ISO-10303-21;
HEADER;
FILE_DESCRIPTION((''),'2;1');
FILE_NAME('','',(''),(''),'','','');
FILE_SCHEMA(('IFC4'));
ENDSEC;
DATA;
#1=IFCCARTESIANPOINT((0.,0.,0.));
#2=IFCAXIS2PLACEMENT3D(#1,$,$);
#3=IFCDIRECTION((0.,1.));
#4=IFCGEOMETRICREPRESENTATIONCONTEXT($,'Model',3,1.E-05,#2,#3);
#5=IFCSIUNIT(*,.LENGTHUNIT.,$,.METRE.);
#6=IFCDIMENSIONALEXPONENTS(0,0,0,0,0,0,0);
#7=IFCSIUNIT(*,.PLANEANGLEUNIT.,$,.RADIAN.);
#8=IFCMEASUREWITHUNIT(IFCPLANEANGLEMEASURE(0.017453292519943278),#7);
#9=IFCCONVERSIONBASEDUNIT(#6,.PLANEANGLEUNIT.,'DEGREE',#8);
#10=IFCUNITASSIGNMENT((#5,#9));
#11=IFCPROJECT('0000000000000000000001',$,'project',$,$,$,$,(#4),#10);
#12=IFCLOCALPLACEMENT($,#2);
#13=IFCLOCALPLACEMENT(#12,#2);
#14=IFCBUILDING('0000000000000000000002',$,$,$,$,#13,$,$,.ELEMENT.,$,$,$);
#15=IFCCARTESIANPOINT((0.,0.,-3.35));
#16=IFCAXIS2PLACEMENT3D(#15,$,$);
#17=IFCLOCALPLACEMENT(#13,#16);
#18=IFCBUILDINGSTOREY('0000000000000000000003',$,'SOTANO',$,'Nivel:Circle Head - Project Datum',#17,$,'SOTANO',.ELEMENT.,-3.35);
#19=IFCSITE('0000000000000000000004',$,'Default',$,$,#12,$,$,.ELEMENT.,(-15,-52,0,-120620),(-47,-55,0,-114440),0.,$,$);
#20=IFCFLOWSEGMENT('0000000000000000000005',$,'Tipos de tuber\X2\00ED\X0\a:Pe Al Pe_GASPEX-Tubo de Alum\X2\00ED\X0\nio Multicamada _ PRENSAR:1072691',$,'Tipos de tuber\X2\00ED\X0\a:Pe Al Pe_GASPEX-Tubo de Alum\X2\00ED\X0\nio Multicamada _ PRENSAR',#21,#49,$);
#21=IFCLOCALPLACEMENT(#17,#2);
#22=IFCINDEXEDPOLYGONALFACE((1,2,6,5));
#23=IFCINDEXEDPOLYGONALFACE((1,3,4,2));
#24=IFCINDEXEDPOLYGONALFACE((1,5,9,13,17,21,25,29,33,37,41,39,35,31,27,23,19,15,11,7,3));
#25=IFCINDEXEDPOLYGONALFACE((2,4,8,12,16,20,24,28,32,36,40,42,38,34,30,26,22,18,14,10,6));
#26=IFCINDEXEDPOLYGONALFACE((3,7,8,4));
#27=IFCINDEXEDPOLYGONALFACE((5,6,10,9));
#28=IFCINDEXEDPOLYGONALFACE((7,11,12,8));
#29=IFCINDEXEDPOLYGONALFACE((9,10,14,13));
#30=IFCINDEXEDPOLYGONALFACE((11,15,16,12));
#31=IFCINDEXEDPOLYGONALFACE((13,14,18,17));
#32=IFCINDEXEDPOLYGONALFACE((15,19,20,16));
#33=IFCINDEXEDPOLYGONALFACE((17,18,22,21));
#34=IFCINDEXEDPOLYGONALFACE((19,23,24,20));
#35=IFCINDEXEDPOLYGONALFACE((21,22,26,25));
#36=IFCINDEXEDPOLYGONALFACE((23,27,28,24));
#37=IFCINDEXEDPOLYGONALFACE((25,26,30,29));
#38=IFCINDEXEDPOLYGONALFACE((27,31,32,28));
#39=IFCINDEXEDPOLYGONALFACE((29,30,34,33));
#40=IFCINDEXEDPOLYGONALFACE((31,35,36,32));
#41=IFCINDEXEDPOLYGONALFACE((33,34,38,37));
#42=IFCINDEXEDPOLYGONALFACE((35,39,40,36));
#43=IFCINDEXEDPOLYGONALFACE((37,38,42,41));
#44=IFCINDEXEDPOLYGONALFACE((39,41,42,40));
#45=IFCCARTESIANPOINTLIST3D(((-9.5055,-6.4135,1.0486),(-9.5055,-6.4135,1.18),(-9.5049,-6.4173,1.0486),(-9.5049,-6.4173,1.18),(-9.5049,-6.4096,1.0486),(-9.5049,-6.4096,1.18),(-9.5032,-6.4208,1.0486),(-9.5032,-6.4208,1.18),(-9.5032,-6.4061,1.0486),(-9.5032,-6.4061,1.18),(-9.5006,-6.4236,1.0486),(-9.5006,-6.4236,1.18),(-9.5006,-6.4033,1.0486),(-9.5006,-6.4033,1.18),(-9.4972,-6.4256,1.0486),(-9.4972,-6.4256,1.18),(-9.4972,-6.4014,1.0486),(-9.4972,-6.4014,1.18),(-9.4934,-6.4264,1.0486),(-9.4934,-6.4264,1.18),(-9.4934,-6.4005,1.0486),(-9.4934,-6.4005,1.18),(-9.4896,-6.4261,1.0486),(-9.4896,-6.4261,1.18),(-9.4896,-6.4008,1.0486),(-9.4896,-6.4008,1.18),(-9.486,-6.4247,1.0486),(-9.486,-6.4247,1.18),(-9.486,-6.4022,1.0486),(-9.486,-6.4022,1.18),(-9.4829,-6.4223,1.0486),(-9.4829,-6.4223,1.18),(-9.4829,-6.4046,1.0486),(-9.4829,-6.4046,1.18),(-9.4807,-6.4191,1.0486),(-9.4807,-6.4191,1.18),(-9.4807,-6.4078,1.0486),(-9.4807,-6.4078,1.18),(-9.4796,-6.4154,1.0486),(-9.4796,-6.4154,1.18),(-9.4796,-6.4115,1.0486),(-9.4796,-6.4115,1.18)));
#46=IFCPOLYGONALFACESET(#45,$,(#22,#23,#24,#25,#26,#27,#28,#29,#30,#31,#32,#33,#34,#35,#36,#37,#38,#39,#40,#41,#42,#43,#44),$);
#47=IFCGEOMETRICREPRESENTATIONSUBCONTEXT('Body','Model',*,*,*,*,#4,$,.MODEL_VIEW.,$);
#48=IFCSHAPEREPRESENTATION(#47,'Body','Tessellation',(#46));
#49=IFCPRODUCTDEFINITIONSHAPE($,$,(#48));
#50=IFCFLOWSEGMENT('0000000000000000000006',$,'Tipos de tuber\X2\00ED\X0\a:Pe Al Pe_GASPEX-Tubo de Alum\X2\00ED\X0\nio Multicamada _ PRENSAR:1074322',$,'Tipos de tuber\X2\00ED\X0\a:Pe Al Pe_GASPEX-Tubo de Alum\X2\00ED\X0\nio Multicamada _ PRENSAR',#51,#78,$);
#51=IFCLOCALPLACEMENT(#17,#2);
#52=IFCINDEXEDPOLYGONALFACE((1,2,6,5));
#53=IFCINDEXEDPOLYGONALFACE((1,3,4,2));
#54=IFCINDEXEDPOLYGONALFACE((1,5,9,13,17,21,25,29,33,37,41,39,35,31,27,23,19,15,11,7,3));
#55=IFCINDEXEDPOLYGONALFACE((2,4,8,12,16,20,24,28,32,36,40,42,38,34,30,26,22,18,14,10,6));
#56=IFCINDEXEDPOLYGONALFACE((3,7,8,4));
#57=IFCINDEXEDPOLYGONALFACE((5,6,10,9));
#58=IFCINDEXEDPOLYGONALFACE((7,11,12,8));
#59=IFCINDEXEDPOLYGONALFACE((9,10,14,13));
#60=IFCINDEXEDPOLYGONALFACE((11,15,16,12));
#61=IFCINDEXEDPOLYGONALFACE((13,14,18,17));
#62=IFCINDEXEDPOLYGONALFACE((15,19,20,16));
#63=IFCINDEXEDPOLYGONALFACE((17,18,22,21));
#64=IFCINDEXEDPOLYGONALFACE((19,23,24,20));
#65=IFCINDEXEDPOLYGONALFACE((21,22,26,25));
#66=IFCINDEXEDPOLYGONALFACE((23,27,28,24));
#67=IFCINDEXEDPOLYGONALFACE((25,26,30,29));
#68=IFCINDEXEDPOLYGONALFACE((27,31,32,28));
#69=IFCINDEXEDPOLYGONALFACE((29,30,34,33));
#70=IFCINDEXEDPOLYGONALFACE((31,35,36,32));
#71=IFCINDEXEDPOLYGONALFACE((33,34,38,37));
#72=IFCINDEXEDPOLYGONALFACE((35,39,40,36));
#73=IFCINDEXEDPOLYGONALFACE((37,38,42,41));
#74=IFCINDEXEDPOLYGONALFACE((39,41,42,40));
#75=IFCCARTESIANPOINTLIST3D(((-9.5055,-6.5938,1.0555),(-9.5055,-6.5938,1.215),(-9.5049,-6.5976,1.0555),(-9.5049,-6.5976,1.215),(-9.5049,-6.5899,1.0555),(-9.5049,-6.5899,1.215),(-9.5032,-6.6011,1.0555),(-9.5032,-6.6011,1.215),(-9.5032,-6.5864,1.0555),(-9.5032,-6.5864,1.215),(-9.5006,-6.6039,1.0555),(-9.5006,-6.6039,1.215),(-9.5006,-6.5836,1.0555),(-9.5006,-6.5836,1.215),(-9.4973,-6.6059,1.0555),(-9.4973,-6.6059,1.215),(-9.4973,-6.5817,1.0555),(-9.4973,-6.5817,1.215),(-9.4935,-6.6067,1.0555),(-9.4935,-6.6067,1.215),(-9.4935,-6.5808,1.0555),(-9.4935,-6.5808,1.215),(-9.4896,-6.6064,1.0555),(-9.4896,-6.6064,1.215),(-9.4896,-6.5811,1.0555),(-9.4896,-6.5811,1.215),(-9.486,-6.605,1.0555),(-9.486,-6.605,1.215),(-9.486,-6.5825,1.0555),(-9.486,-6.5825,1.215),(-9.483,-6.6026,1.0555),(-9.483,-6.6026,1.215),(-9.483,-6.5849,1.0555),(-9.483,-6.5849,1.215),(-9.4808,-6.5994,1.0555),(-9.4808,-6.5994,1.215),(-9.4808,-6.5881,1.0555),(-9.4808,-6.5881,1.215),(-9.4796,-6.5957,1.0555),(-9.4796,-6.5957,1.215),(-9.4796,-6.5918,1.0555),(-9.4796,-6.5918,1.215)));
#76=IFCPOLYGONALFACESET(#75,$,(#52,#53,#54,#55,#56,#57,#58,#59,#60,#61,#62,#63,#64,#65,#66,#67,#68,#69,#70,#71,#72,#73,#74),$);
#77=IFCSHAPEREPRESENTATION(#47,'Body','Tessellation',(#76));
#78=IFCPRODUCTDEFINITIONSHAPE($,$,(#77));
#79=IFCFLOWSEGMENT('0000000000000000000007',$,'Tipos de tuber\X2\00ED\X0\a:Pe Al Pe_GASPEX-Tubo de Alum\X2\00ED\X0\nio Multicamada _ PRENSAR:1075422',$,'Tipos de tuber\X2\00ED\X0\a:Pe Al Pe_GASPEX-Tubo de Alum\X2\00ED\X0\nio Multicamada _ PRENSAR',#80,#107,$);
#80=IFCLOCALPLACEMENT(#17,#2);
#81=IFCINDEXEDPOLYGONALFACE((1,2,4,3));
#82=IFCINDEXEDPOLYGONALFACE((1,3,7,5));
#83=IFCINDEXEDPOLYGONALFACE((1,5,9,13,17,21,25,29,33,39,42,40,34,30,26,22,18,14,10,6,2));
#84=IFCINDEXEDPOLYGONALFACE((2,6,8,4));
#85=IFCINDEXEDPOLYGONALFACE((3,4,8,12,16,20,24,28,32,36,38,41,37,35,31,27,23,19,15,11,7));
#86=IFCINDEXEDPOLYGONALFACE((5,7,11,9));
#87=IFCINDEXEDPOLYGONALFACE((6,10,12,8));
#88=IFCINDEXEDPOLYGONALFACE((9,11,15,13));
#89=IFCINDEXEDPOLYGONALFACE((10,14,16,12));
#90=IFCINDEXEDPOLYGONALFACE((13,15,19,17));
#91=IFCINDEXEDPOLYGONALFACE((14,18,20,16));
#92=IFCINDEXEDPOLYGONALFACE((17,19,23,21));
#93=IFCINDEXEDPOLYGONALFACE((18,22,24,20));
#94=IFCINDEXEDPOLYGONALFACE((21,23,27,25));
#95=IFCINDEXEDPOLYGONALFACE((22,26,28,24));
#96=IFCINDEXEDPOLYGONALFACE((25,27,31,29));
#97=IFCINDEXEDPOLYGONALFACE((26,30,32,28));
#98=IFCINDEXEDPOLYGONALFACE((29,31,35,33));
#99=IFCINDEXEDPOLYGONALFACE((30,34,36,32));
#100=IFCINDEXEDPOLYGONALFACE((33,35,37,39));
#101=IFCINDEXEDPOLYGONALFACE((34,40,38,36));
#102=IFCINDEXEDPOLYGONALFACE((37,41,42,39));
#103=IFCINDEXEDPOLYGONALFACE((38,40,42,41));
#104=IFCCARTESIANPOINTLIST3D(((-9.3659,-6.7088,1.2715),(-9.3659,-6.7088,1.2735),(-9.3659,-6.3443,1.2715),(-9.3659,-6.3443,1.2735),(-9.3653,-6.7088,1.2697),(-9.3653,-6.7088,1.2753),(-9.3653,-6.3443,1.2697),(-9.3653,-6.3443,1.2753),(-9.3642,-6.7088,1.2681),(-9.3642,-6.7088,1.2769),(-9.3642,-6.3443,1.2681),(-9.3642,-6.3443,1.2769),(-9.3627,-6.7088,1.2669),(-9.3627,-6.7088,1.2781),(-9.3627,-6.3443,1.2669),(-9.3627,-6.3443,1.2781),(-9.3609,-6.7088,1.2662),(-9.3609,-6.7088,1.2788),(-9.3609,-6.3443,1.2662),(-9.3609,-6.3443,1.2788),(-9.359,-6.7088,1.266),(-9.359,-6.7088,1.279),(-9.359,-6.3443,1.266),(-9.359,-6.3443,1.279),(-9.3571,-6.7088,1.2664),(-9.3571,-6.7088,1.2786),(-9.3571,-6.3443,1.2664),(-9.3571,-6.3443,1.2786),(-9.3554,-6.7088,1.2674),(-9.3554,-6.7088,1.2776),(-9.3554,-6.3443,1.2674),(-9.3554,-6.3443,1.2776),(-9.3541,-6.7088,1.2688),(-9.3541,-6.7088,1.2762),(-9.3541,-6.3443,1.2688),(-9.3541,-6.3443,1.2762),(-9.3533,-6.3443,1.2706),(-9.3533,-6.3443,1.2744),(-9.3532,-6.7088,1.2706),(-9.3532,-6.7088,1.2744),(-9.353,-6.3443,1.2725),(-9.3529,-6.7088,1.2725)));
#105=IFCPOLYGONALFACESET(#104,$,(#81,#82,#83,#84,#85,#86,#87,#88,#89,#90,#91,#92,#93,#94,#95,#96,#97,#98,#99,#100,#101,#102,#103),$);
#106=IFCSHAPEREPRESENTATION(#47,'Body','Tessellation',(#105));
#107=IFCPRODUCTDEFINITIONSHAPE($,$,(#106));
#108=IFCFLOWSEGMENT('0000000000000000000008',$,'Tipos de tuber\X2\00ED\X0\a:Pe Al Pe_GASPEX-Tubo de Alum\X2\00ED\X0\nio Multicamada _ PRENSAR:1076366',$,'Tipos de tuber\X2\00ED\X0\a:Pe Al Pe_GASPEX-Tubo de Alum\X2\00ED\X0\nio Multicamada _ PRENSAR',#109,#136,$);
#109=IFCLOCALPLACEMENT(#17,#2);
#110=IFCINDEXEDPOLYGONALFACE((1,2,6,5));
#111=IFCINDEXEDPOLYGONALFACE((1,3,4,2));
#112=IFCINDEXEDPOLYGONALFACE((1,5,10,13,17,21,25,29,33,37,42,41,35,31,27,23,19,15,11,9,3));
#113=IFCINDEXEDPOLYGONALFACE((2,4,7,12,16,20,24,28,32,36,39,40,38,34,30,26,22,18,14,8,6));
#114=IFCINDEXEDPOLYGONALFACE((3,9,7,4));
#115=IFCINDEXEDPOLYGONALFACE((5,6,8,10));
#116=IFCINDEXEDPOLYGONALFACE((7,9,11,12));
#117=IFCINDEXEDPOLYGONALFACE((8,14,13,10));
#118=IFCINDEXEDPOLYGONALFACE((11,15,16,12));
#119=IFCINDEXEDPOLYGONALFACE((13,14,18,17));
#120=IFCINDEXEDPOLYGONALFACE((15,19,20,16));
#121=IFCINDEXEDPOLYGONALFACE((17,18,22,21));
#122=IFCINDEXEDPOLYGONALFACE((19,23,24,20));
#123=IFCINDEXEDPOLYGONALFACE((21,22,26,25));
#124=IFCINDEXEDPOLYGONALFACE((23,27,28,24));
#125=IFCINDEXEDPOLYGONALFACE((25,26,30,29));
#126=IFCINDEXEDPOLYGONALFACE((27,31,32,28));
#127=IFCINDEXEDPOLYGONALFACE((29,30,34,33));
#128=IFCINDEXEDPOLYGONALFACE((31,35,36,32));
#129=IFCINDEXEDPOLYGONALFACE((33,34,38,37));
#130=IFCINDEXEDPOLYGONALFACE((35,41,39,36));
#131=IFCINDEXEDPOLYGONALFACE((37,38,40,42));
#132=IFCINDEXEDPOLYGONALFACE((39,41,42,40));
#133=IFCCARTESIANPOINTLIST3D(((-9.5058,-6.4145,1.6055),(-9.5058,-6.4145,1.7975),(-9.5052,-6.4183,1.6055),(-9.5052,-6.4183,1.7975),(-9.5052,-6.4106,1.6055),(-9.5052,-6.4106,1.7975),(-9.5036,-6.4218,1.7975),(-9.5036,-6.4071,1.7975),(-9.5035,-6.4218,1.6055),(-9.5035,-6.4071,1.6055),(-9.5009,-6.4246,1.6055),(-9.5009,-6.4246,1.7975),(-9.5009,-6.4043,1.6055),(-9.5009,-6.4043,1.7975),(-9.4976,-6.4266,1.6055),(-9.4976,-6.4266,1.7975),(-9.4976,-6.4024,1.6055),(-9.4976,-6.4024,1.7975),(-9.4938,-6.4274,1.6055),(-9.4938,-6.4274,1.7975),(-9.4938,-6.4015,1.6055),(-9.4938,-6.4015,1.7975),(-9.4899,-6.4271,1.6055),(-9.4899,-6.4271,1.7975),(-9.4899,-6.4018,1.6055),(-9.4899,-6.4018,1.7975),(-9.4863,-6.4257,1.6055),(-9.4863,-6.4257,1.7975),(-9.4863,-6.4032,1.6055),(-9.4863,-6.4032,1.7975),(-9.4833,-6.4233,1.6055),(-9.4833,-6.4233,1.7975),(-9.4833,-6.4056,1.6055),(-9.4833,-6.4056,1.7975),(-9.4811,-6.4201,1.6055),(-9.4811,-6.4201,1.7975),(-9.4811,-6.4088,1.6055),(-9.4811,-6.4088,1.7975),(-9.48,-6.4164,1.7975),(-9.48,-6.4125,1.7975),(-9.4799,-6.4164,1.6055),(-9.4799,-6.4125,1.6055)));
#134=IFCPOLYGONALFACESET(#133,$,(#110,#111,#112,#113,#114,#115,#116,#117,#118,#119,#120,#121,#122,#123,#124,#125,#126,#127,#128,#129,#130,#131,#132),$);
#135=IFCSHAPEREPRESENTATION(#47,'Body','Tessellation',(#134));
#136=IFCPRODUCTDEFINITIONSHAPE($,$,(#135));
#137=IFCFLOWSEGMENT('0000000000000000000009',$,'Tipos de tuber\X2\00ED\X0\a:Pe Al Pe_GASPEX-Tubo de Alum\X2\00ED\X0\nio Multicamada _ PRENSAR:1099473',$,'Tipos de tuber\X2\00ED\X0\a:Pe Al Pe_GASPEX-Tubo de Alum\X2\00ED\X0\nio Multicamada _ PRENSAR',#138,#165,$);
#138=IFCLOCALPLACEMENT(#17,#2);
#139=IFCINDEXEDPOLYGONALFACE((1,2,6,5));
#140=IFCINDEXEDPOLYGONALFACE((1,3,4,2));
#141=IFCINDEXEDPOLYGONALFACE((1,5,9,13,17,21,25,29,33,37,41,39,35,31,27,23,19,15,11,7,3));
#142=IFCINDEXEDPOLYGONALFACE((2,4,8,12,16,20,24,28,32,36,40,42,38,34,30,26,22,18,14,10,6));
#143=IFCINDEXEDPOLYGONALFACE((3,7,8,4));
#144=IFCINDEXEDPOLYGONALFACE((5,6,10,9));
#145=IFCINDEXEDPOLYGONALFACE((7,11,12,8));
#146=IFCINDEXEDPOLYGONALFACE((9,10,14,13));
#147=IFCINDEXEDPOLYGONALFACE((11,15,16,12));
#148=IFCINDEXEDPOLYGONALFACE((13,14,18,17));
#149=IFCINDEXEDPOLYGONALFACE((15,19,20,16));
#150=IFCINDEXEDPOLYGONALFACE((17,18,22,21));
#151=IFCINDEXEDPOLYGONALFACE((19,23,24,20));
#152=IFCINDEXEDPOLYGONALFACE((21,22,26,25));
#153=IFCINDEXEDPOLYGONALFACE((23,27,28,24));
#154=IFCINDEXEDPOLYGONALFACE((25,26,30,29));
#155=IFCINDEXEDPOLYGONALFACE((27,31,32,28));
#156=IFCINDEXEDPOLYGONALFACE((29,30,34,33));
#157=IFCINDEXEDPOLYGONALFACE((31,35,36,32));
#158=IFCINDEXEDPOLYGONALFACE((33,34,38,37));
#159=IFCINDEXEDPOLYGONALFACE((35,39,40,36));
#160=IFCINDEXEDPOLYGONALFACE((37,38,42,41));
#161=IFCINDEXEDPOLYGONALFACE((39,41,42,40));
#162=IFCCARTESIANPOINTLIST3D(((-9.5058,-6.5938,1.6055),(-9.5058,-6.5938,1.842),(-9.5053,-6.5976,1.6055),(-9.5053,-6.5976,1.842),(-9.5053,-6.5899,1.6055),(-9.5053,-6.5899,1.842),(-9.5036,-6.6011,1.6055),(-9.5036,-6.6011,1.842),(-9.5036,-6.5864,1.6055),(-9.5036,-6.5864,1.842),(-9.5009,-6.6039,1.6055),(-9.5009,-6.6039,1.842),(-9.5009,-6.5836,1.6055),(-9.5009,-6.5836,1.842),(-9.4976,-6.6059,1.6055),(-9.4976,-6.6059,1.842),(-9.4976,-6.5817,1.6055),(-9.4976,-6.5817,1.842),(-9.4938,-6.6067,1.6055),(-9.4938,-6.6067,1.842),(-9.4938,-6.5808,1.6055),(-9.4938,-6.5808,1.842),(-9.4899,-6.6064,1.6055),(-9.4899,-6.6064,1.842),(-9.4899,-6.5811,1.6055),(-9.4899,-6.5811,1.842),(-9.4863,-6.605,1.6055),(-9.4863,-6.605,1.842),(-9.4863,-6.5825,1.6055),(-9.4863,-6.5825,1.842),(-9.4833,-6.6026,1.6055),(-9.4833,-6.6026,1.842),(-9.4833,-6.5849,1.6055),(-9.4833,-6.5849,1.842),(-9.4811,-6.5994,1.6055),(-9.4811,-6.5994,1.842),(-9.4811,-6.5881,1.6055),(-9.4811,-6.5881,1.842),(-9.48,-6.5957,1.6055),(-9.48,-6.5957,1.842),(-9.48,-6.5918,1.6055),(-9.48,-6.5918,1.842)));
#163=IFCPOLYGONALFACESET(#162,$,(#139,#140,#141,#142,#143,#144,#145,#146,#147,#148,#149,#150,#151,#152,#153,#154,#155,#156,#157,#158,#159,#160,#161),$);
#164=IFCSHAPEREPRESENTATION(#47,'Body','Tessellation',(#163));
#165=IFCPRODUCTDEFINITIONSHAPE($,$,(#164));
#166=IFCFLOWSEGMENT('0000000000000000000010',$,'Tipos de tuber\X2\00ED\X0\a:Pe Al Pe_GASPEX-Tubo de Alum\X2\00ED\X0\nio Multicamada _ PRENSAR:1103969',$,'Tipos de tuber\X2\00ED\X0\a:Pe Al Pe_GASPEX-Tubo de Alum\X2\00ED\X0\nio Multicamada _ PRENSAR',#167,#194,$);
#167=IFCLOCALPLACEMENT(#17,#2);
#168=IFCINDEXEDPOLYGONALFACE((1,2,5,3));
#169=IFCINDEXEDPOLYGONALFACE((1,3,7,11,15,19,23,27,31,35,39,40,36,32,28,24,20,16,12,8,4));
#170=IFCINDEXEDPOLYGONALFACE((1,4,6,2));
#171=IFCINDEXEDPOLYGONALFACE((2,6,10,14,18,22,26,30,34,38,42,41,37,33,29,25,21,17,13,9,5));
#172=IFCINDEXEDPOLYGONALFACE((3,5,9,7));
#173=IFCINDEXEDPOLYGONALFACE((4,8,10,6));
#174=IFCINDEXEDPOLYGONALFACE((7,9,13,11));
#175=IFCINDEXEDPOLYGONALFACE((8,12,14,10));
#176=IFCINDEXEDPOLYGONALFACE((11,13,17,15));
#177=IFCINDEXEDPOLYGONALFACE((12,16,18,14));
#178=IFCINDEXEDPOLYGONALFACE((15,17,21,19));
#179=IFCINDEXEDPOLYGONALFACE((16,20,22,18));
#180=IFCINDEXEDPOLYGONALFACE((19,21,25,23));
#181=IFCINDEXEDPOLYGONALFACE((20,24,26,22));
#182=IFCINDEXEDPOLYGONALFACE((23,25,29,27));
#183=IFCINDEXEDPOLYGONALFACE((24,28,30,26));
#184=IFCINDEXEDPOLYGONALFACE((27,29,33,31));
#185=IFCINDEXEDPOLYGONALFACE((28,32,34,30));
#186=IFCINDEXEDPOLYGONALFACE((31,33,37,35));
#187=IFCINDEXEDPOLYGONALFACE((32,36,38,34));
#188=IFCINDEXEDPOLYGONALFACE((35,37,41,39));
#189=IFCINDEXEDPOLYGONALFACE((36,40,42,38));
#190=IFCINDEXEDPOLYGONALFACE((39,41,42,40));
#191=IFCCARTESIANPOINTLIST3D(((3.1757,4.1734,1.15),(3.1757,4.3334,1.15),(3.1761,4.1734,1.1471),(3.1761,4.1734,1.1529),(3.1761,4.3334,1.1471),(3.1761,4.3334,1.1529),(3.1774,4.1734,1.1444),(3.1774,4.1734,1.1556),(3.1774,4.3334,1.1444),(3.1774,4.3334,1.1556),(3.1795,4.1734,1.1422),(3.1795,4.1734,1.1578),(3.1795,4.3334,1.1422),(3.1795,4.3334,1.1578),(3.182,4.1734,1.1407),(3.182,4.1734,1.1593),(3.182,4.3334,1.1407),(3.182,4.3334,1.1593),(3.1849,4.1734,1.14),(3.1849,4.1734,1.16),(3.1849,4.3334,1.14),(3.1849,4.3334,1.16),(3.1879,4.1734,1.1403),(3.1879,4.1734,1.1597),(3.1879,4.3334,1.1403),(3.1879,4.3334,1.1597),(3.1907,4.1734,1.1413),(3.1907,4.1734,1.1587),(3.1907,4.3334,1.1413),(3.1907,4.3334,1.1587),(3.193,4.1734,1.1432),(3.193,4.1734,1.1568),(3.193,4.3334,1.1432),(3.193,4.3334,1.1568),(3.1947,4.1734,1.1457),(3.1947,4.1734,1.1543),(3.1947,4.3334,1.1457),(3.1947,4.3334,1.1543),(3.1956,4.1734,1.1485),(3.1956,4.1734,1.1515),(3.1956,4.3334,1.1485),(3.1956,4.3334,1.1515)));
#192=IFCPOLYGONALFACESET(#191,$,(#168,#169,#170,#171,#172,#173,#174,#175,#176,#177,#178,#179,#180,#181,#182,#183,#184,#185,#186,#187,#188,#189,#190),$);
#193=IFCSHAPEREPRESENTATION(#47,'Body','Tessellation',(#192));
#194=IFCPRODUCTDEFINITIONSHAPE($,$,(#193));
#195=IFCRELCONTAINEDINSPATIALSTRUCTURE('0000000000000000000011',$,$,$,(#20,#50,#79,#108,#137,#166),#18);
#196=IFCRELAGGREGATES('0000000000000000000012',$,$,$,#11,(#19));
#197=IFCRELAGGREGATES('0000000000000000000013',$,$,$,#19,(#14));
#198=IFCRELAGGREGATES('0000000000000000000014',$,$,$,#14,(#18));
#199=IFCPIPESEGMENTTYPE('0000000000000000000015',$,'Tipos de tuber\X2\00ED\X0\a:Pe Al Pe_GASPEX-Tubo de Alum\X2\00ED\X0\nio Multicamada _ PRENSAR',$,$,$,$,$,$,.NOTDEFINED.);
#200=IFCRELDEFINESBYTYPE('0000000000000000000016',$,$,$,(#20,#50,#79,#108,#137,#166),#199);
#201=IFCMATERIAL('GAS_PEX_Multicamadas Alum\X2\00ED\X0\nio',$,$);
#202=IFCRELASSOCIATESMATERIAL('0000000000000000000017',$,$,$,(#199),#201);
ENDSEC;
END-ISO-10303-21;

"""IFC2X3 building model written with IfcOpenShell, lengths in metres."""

from ifc_helpers import new_model, entity, si_unit, converted_unit, direction, frame, frame_2d, origin, origin_2d_with_axis, place, context, subcontext, project, spatial, circle, extrude, material, type_object, element, save


model = new_model("IFC2X3")

# Units and contexts
model_context = context("Model", 3, precision=1e-05, world=origin(), true_north=direction((0.0, 1.0)))
body_context = subcontext(model_context, "Body", "Model", "MODEL_VIEW")
ifc_project = project(units=[si_unit("LENGTHUNIT", "METRE"), converted_unit("PLANEANGLEUNIT", "DEGREE", entity("IfcPlaneAngleMeasure", 0.017453292519943278), si_unit("PLANEANGLEUNIT", "RADIAN"), dimensions=[0, 0, 0, 0, 0, 0, 0])], contexts=[model_context])

# Site, building, storey
site_placement = place(None, origin())
site = spatial("IfcSite", under=ifc_project, at=site_placement, Name="Default", CompositionType="ELEMENT", RefLatitude=(-15, -52, 0, -120620), RefLongitude=(-47, -55, 0, -114440), RefElevation=0.0)
building_placement = place(site_placement, origin())
building = spatial("IfcBuilding", under=site, at=building_placement, CompositionType="ELEMENT")
storey_placement = place(building_placement, frame((0.0, 0.0, -3.35)))
storey = spatial("IfcBuildingStorey", under=building, at=storey_placement, Name="SOTANO", ObjectType="Nivel:Circle Head - Project Datum", LongName="SOTANO", CompositionType="ELEMENT", Elevation=-3.35)

# Flow segments
ifc_material = material(Name="GAS_PEX_Multicamadas Alumínio")
pipe_segment_type_1 = type_object("IfcPipeSegmentType", Name="Tipos de tubería:Pe Al Pe_GASPEX-Tubo de Alumínio Multicamada _ PRENSAR", PredefinedType="NOTDEFINED", material=ifc_material)
flow_segment_1_placement = place(storey_placement, origin())
element("IfcFlowSegment", 1, at=flow_segment_1_placement, inside=storey, type_object=pipe_segment_type_1, Name="Tipos de tubería:Pe Al Pe_GASPEX-Tubo de Alumínio Multicamada _ PRENSAR:1072691", ObjectType="Tipos de tubería:Pe Al Pe_GASPEX-Tubo de Alumínio Multicamada _ PRENSAR", context=body_context, shape_type="SweptSolid", body=[
    extrude(circle(Radius=0.013, at=frame_2d((0.0, 0.0), x_axis=(1.0, 0.0))), frame((-9.4925, -6.4135, 1.0486), z_axis=(0.0, 0.0, 1.0), x_axis=(-1.0, 0.0, 0.0)), (0.0, 0.0, 1.0), 0.1314),
])
flow_segment_2_placement = place(storey_placement, origin())
element("IfcFlowSegment", 2, at=flow_segment_2_placement, inside=storey, type_object=pipe_segment_type_1, Name="Tipos de tubería:Pe Al Pe_GASPEX-Tubo de Alumínio Multicamada _ PRENSAR:1074322", ObjectType="Tipos de tubería:Pe Al Pe_GASPEX-Tubo de Alumínio Multicamada _ PRENSAR", context=body_context, shape_type="SweptSolid", body=[
    extrude(circle(Radius=0.013, at=origin_2d_with_axis()), frame((-9.4925, -6.5938, 1.0555), z_axis=(0.0, 0.0, 1.0), x_axis=(-1.0, 0.0, 0.0)), (0.0, 0.0, 1.0), 0.1595),
])
flow_segment_3_placement = place(storey_placement, origin())
element("IfcFlowSegment", 3, at=flow_segment_3_placement, inside=storey, type_object=pipe_segment_type_1, Name="Tipos de tubería:Pe Al Pe_GASPEX-Tubo de Alumínio Multicamada _ PRENSAR:1075422", ObjectType="Tipos de tubería:Pe Al Pe_GASPEX-Tubo de Alumínio Multicamada _ PRENSAR", context=body_context, shape_type="SweptSolid", body=[
    extrude(circle(Radius=0.0065, at=frame_2d((0.0, 0.0), x_axis=(1.0, 0.0))), frame((-9.3595, -6.3443, 1.2725), z_axis=(0.000095, -1.0, 0.0), x_axis=(1.0, 0.000095, 0.0)), (0.0, 0.0, 1.0), 0.3644),
])
flow_segment_4_placement = place(storey_placement, origin())
element("IfcFlowSegment", 4, at=flow_segment_4_placement, inside=storey, type_object=pipe_segment_type_1, Name="Tipos de tubería:Pe Al Pe_GASPEX-Tubo de Alumínio Multicamada _ PRENSAR:1076366", ObjectType="Tipos de tubería:Pe Al Pe_GASPEX-Tubo de Alumínio Multicamada _ PRENSAR", context=body_context, shape_type="SweptSolid", body=[
    extrude(circle(Radius=0.013, at=frame_2d((0.0, 0.0), x_axis=(1.0, 0.0))), frame((-9.4928, -6.4145, 1.6055), z_axis=(-0.00008, 0.0, 1.0), x_axis=(-1.0, 0.0, -0.00008)), (0.0, 0.0, 1.0), 0.192),
])
flow_segment_5_placement = place(storey_placement, origin())
element("IfcFlowSegment", 5, at=flow_segment_5_placement, inside=storey, type_object=pipe_segment_type_1, Name="Tipos de tubería:Pe Al Pe_GASPEX-Tubo de Alumínio Multicamada _ PRENSAR:1099473", ObjectType="Tipos de tubería:Pe Al Pe_GASPEX-Tubo de Alumínio Multicamada _ PRENSAR", context=body_context, shape_type="SweptSolid", body=[
    extrude(circle(Radius=0.013, at=frame_2d((0.0, 0.0), x_axis=(1.0, 0.0))), frame((-9.4928, -6.5938, 1.6055), z_axis=(0.00002, 0.0, 1.0), x_axis=(-1.0, 0.0, 0.00002)), (0.0, 0.0, 1.0), 0.2365),
])
flow_segment_6_placement = place(storey_placement, origin())
element("IfcFlowSegment", 6, at=flow_segment_6_placement, inside=storey, type_object=pipe_segment_type_1, Name="Tipos de tubería:Pe Al Pe_GASPEX-Tubo de Alumínio Multicamada _ PRENSAR:1103969", ObjectType="Tipos de tubería:Pe Al Pe_GASPEX-Tubo de Alumínio Multicamada _ PRENSAR", context=body_context, shape_type="SweptSolid", body=[
    extrude(circle(Radius=0.01, at=origin_2d_with_axis()), frame((3.1857, 4.1734, 1.15), z_axis=(0.0, 1.0, 0.0), x_axis=(-1.0, 0.0, 0.0)), (0.0, 0.0, 1.0), 0.16),
])

save(model, "model.ifc")
